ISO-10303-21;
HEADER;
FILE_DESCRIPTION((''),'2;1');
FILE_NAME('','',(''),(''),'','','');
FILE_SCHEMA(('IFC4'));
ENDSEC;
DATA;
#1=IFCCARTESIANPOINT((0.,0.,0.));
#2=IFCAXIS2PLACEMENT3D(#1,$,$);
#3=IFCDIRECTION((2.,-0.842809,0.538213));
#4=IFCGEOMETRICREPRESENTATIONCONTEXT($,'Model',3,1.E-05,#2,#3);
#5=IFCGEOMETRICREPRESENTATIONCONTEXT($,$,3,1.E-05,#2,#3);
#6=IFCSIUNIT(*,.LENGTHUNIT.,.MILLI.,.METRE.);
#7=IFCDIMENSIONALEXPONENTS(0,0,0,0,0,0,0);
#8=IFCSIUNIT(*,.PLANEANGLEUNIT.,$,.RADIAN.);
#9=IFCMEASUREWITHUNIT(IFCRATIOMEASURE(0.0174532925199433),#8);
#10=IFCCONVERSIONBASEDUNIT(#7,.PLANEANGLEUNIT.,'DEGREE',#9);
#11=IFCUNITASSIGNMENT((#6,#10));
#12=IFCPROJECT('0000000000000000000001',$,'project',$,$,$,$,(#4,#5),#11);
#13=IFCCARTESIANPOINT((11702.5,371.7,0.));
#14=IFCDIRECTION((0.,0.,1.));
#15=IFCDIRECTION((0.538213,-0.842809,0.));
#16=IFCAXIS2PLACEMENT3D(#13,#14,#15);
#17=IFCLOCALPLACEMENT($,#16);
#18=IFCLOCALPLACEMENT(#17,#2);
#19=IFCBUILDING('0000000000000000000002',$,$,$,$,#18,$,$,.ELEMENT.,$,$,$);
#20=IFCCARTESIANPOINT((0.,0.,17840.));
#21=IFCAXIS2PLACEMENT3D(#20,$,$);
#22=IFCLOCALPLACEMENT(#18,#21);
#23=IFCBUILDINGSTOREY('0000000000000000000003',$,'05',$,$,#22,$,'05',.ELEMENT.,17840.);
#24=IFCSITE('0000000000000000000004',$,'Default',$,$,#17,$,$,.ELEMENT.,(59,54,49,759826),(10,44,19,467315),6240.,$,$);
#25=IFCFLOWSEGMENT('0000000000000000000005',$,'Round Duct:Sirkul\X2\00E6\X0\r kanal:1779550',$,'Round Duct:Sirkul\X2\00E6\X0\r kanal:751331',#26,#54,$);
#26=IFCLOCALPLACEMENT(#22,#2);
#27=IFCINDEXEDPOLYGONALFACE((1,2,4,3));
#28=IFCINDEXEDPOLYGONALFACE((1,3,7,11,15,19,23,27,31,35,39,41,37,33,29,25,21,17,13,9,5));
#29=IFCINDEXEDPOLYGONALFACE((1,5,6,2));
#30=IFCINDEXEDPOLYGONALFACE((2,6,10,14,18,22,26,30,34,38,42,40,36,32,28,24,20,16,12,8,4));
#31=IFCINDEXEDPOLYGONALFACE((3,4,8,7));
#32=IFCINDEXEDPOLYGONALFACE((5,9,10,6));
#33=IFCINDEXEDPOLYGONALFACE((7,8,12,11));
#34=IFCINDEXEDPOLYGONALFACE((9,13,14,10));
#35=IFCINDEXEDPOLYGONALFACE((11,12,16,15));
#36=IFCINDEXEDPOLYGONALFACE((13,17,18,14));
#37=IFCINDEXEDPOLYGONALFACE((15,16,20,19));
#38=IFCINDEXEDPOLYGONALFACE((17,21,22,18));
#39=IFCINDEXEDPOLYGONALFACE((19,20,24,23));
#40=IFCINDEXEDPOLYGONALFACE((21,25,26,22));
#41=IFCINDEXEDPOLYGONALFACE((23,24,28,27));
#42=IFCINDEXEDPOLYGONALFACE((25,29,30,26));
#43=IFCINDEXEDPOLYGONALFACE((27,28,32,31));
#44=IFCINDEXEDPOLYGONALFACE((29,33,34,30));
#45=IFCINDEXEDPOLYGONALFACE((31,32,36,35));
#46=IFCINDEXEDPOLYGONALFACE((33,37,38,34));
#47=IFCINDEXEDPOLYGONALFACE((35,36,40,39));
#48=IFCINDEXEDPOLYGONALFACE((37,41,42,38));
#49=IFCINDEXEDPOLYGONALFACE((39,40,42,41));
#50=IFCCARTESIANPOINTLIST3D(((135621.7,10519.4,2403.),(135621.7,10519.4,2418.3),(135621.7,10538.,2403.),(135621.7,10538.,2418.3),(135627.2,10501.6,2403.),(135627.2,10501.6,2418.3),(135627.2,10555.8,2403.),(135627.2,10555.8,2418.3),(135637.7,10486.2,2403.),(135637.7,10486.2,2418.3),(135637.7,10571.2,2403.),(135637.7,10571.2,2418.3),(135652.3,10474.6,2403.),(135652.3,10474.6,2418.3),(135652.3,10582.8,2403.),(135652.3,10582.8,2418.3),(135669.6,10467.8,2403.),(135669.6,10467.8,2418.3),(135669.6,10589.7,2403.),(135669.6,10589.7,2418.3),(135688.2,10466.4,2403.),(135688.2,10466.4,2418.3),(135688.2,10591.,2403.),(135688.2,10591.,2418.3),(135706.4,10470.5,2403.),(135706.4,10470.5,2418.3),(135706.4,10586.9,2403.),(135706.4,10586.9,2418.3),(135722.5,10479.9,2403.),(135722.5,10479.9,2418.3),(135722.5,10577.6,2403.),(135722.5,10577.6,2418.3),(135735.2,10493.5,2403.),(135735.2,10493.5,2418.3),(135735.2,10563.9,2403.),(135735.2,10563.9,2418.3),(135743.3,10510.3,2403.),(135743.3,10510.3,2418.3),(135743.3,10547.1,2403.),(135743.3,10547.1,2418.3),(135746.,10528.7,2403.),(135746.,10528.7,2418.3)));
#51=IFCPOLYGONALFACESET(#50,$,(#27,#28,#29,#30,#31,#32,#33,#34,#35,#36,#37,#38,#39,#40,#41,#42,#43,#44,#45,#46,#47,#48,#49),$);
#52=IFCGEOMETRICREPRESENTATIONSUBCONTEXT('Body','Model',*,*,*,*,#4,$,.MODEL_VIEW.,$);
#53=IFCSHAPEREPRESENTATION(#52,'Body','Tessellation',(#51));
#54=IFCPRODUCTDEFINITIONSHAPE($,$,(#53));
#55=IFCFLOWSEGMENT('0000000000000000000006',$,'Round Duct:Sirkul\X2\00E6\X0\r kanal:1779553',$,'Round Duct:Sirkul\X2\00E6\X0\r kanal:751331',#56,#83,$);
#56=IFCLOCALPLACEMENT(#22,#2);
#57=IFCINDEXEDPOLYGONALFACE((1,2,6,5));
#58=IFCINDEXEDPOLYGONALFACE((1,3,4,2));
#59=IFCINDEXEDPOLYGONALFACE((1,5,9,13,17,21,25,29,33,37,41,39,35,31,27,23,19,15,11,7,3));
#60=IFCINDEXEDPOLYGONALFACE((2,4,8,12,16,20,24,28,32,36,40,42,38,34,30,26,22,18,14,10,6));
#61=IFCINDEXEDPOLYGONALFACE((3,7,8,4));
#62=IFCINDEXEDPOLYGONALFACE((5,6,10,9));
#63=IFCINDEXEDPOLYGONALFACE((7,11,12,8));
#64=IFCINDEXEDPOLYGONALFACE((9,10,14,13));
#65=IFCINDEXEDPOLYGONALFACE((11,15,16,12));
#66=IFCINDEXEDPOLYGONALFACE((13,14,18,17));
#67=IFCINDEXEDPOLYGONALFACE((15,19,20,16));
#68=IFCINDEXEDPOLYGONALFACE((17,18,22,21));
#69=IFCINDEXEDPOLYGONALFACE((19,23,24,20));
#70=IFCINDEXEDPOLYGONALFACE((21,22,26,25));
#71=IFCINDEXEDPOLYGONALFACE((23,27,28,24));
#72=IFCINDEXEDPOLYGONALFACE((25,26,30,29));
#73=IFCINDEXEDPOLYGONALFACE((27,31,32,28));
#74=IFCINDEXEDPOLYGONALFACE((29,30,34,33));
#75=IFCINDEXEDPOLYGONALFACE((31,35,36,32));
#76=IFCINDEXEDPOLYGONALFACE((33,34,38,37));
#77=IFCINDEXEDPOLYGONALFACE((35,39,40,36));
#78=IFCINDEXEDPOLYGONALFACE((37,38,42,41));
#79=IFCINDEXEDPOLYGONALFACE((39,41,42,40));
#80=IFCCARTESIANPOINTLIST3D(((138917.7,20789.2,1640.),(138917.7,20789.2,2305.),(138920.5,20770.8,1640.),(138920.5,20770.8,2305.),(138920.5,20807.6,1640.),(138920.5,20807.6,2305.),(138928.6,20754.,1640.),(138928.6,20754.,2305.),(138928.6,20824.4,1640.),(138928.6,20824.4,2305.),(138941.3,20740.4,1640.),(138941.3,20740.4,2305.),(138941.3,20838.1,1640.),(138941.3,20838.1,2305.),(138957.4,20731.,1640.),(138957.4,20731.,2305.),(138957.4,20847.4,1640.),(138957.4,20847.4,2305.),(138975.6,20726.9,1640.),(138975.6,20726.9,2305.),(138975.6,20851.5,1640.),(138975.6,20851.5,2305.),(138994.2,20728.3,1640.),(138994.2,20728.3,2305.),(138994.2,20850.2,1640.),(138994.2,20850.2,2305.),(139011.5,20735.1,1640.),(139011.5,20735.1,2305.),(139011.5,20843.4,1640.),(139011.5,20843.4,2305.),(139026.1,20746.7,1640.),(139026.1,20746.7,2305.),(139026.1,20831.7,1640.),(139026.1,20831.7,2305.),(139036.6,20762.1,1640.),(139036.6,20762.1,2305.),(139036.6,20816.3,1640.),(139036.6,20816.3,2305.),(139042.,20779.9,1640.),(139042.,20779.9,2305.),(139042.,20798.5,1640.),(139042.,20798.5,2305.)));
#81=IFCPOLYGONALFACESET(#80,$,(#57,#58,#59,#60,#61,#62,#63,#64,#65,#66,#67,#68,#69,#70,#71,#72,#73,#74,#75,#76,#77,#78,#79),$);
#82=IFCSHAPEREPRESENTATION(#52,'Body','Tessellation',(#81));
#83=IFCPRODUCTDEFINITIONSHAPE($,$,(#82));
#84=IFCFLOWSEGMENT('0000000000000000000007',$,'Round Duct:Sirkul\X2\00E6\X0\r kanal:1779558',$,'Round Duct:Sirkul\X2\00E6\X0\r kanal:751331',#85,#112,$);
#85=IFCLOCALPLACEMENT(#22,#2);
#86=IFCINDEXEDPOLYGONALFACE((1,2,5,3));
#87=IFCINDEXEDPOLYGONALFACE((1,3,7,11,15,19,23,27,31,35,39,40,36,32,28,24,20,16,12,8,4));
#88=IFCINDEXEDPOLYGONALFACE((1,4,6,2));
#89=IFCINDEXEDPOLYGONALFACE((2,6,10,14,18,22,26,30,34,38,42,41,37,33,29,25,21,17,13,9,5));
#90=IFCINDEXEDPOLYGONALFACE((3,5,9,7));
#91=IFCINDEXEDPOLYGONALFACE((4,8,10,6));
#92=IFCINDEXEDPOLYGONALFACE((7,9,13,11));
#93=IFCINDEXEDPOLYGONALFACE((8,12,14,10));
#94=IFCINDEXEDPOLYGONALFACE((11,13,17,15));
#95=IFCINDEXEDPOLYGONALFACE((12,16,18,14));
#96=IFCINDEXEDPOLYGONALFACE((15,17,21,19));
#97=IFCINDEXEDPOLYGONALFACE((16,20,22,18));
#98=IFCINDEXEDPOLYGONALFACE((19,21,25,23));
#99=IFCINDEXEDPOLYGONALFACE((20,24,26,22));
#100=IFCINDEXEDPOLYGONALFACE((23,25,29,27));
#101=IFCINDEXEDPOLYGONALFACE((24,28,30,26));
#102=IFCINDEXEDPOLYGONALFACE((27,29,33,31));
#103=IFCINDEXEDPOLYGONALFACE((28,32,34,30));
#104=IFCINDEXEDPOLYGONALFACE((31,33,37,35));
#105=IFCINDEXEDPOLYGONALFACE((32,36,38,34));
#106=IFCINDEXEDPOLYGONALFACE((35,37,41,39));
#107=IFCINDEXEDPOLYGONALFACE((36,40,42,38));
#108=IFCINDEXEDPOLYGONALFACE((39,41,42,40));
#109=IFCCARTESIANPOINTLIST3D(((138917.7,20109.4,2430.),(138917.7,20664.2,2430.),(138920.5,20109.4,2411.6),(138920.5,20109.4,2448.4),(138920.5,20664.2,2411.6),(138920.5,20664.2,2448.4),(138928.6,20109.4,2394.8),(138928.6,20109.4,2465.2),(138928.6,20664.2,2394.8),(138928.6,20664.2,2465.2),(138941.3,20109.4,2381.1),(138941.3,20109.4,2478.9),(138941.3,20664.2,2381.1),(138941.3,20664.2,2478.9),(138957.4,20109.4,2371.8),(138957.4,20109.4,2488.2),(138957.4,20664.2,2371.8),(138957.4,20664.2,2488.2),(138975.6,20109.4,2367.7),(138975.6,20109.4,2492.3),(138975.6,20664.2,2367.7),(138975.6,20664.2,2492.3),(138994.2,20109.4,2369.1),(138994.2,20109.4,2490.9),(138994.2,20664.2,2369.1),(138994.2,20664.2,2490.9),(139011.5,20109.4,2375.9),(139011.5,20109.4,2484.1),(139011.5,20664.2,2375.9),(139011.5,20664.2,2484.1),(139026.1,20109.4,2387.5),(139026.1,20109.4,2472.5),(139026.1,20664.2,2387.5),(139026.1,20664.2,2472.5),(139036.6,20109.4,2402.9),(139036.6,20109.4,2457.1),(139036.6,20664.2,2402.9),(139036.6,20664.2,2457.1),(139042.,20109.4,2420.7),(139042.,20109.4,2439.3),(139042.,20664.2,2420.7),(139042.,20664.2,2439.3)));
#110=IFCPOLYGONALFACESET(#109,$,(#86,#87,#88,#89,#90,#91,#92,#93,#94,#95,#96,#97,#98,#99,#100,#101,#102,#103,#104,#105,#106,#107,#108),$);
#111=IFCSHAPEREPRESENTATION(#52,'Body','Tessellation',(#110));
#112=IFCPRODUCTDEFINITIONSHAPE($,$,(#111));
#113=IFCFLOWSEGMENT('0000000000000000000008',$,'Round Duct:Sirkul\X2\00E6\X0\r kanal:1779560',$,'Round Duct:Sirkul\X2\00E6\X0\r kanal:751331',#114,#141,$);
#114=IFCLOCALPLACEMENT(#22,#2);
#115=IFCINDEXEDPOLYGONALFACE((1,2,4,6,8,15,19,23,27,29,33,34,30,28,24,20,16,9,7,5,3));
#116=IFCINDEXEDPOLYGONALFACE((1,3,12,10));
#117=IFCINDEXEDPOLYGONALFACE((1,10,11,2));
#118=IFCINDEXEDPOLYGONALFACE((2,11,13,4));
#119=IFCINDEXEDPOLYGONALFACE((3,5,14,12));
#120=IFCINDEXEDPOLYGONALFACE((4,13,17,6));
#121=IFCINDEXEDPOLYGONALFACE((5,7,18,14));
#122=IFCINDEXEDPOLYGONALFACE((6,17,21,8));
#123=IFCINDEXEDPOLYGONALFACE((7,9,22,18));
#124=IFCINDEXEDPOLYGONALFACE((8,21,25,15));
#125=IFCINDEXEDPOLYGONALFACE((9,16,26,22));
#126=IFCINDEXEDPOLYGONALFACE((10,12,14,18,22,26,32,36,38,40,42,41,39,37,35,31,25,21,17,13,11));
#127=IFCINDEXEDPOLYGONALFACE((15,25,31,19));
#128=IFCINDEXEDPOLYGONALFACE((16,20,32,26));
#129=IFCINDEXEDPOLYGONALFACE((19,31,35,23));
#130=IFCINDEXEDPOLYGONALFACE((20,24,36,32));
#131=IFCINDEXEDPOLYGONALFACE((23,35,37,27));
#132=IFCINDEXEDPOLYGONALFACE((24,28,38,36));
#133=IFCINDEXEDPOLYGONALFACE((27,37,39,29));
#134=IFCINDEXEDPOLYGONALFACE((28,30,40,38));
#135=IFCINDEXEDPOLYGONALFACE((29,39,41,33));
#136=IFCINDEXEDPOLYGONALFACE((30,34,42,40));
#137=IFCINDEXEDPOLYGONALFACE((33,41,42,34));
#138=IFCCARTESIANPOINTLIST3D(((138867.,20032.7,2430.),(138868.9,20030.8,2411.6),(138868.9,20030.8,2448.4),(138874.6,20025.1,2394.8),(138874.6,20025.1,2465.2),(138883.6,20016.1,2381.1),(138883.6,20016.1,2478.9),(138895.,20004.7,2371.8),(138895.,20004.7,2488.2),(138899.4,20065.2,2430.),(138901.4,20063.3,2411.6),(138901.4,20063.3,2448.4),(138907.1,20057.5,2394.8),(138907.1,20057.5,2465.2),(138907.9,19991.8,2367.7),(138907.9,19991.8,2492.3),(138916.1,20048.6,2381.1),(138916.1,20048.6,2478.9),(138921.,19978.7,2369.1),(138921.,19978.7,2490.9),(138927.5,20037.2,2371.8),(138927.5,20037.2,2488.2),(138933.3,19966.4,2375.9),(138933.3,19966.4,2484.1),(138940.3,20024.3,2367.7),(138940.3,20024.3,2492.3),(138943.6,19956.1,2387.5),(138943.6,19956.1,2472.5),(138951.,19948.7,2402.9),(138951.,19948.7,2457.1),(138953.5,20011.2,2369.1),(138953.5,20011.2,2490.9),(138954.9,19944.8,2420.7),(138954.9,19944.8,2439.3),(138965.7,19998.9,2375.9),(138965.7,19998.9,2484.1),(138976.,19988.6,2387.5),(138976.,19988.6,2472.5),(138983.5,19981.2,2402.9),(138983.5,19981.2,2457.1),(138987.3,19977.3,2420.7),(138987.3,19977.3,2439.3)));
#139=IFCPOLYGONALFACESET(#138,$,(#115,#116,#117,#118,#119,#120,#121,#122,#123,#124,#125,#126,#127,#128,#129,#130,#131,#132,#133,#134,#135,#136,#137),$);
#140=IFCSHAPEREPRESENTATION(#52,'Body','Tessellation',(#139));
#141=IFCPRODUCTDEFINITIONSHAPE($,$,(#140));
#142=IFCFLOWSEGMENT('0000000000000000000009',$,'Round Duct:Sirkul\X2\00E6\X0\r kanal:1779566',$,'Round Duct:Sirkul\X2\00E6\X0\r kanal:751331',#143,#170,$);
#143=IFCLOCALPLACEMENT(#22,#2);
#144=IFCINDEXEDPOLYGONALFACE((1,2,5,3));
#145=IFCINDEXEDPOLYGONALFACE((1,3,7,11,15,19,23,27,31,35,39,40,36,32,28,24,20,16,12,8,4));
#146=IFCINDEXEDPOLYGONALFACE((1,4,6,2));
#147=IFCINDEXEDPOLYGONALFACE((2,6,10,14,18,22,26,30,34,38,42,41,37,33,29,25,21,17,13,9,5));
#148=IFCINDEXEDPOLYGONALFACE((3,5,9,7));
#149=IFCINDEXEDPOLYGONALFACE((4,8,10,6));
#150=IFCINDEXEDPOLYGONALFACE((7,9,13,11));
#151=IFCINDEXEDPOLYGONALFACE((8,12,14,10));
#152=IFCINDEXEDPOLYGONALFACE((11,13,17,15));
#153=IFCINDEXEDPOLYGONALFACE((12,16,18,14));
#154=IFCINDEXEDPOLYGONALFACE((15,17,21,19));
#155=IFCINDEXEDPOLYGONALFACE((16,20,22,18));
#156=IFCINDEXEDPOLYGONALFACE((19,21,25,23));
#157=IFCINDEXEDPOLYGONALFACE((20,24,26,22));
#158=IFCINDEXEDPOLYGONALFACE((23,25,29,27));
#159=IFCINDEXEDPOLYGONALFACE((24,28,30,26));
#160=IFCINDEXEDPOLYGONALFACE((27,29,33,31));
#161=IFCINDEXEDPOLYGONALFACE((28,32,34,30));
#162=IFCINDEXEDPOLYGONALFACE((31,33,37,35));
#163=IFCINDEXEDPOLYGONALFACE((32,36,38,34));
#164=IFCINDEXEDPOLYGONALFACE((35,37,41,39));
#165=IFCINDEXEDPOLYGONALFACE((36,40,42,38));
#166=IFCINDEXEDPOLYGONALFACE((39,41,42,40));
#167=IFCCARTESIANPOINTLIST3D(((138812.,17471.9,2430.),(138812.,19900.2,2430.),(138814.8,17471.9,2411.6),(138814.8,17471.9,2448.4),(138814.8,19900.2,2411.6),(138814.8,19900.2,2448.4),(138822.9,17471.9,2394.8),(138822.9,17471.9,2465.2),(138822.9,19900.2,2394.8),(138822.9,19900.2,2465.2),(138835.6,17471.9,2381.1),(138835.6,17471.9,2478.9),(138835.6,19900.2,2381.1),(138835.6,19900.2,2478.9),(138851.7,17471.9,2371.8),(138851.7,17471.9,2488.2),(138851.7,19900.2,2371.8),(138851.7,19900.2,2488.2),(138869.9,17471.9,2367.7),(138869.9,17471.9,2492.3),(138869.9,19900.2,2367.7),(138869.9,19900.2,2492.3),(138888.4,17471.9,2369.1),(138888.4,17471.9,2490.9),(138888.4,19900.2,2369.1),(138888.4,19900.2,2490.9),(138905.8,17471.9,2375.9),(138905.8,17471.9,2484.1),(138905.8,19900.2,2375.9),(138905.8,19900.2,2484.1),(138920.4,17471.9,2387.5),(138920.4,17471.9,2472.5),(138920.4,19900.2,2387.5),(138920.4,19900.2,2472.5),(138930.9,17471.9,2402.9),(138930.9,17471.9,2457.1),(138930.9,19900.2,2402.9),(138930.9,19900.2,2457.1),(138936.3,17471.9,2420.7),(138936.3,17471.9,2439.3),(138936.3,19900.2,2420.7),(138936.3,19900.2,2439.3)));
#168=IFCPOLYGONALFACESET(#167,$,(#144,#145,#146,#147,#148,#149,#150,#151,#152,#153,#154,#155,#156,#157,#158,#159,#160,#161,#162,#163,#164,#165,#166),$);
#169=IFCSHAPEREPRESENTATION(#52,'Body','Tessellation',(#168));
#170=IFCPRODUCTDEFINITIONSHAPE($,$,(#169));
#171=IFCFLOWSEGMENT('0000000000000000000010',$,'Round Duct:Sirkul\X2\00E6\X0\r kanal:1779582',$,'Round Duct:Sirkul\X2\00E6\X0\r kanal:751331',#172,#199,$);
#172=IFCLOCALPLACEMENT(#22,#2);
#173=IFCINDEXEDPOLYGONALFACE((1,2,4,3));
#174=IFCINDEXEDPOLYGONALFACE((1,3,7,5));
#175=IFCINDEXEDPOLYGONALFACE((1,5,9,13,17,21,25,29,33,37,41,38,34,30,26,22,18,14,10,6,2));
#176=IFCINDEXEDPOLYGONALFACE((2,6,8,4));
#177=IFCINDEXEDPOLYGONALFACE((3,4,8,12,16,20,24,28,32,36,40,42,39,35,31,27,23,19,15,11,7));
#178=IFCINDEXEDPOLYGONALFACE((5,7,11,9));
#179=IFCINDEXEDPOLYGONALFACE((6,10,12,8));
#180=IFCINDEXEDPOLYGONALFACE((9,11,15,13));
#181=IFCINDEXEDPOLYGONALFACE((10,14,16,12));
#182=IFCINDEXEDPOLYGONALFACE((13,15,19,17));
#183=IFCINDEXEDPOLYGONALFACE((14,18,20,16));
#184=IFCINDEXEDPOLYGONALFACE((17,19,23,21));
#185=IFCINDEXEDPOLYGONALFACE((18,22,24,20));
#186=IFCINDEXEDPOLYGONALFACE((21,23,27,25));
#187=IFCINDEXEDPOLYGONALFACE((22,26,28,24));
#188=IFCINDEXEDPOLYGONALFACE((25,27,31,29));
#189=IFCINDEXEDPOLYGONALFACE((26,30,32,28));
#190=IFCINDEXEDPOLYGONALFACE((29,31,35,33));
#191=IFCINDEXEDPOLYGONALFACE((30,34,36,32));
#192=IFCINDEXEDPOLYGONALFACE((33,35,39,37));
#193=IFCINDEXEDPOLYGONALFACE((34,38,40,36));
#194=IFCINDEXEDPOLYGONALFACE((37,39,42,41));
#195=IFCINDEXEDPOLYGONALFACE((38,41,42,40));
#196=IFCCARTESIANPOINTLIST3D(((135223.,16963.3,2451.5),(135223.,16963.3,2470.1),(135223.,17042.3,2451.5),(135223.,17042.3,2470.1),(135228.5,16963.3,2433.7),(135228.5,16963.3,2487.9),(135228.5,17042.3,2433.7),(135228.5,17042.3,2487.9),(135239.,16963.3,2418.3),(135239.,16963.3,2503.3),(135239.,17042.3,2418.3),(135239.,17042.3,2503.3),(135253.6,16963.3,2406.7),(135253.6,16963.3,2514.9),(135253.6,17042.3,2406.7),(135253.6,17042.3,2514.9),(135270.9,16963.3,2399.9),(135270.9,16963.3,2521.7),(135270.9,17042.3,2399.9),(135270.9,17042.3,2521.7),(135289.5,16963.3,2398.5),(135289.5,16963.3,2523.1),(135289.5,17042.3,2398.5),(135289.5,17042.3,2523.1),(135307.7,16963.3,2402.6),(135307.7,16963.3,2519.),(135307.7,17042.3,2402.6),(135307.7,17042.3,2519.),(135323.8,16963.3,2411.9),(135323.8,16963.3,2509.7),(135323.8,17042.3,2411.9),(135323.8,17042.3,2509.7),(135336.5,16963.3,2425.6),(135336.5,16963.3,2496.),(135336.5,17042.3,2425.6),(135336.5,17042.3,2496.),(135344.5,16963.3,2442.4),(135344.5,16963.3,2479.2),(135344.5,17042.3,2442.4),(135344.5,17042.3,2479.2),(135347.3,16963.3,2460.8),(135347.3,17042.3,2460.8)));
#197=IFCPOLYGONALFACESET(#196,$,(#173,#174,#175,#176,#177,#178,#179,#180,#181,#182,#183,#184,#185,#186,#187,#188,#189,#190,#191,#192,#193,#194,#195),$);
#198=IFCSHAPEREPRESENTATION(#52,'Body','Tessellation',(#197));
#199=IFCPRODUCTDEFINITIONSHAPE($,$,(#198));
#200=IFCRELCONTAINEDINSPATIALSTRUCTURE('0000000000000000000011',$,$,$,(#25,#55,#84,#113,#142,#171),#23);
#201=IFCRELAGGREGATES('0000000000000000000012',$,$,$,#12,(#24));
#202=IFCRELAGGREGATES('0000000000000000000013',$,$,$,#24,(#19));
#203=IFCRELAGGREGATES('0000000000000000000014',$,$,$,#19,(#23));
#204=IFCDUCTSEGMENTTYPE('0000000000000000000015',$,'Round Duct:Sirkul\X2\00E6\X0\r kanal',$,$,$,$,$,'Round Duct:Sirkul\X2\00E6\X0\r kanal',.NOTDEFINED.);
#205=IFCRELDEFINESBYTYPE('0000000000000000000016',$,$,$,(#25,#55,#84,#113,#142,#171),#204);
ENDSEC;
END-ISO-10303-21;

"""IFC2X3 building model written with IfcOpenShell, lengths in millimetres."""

from ifc_helpers import new_model, entity, si_unit, converted_unit, direction, frame, frame_2d, origin, origin_2d_with_axis, place, context, subcontext, project, spatial, circle, extrude, type_object, element, save


model = new_model("IFC2X3")

# Units and contexts
model_context = context("Model", 3, precision=1e-05, world=origin(), true_north=direction((2.0, -0.842809, 0.538213)))
context_of_model = context(None, 3, precision=1e-05, world=origin(), true_north=direction((2.0, -0.842809, 0.538213)))
body_context = subcontext(model_context, "Body", "Model", "MODEL_VIEW")
ifc_project = project(units=[si_unit("LENGTHUNIT", "METRE", prefix="MILLI"), converted_unit("PLANEANGLEUNIT", "DEGREE", entity("IfcRatioMeasure", 0.0174532925199433), si_unit("PLANEANGLEUNIT", "RADIAN"), dimensions=[0, 0, 0, 0, 0, 0, 0])], contexts=[model_context, context_of_model])

# Site, building, storey
site_placement = place(None, frame((11702.5, 371.7, 0.0), z_axis=(0.0, 0.0, 1.0), x_axis=(0.538213, -0.842809, 0.0)))
site = spatial("IfcSite", under=ifc_project, at=site_placement, Name="Default", CompositionType="ELEMENT", RefLatitude=(59, 54, 49, 759826), RefLongitude=(10, 44, 19, 467315), RefElevation=6240.0)
building_placement = place(site_placement, origin())
building = spatial("IfcBuilding", under=site, at=building_placement, CompositionType="ELEMENT")
storey_placement = place(building_placement, frame((0.0, 0.0, 17840.0)))
storey = spatial("IfcBuildingStorey", under=building, at=storey_placement, Name="05", LongName="05", CompositionType="ELEMENT", Elevation=17840.0)

# Flow segments
duct_segment_type = type_object("IfcDuctSegmentType", Name="Round Duct:Sirkulær kanal", ElementType="Round Duct:Sirkulær kanal", PredefinedType="NOTDEFINED")
flow_segment_1_placement = place(storey_placement, origin())
element("IfcFlowSegment", 1, at=flow_segment_1_placement, inside=storey, type_object=duct_segment_type, Name="Round Duct:Sirkulær kanal:1779550", ObjectType="Round Duct:Sirkulær kanal:751331", context=body_context, shape_type="SweptSolid", body=[
    extrude(circle(Radius=62.5, at=frame_2d((0.0, 0.0), x_axis=(1.0, 0.0))), frame((135683.5, 10528.7, 2403.0)), (0.0, 0.0, 1.0), 15.3),
])
flow_segment_2_placement = place(storey_placement, origin())
element("IfcFlowSegment", 2, at=flow_segment_2_placement, inside=storey, type_object=duct_segment_type, Name="Round Duct:Sirkulær kanal:1779553", ObjectType="Round Duct:Sirkulær kanal:751331", context=body_context, shape_type="SweptSolid", body=[
    extrude(circle(Radius=62.5, at=frame_2d((0.0, 0.0), x_axis=(1.0, 0.0))), frame((138980.2, 20789.2, 1640.0), z_axis=(0.0, 0.0, 1.0), x_axis=(-1.0, 0.0, 0.0)), (0.0, 0.0, 1.0), 665.0),
])
flow_segment_3_placement = place(storey_placement, origin())
element("IfcFlowSegment", 3, at=flow_segment_3_placement, inside=storey, type_object=duct_segment_type, Name="Round Duct:Sirkulær kanal:1779558", ObjectType="Round Duct:Sirkulær kanal:751331", context=body_context, shape_type="SweptSolid", body=[
    extrude(circle(Radius=62.5, at=origin_2d_with_axis()), frame((138980.2, 20109.4, 2430.0), z_axis=(0.0, 1.0, 0.0), x_axis=(-1.0, 0.0, 0.0)), (0.0, 0.0, 1.0), 554.8),
])
flow_segment_4_placement = place(storey_placement, origin())
element("IfcFlowSegment", 4, at=flow_segment_4_placement, inside=storey, type_object=duct_segment_type, Name="Round Duct:Sirkulær kanal:1779560", ObjectType="Round Duct:Sirkulær kanal:751331", context=body_context, shape_type="SweptSolid", body=[
    extrude(circle(Radius=62.5, at=origin_2d_with_axis()), frame((138911.2, 19988.5, 2430.0), z_axis=(0.707107, 0.707107, 0.0), x_axis=(-0.707107, 0.707107, 0.0)), (0.0, 0.0, 1.0), 45.9),
])
flow_segment_5_placement = place(storey_placement, origin())
element("IfcFlowSegment", 5, at=flow_segment_5_placement, inside=storey, type_object=duct_segment_type, Name="Round Duct:Sirkulær kanal:1779566", ObjectType="Round Duct:Sirkulær kanal:751331", context=body_context, shape_type="SweptSolid", body=[
    extrude(circle(Radius=62.5, at=origin_2d_with_axis()), frame((138874.5, 17471.9, 2430.0), z_axis=(0.0, 1.0, 0.0), x_axis=(-1.0, 0.0, 0.0)), (0.0, 0.0, 1.0), 2428.2),
])
flow_segment_6_placement = place(storey_placement, origin())
element("IfcFlowSegment", 6, at=flow_segment_6_placement, inside=storey, type_object=duct_segment_type, Name="Round Duct:Sirkulær kanal:1779582", ObjectType="Round Duct:Sirkulær kanal:751331", context=body_context, shape_type="SweptSolid", body=[
    extrude(circle(Radius=62.5, at=origin_2d_with_axis()), frame((135284.8, 16963.3, 2460.8), z_axis=(-0.000023, 1.0, 0.0), x_axis=(1.0, 0.000023, 0.0)), (0.0, 0.0, 1.0), 79.0),
])

save(model, "model.ifc")
